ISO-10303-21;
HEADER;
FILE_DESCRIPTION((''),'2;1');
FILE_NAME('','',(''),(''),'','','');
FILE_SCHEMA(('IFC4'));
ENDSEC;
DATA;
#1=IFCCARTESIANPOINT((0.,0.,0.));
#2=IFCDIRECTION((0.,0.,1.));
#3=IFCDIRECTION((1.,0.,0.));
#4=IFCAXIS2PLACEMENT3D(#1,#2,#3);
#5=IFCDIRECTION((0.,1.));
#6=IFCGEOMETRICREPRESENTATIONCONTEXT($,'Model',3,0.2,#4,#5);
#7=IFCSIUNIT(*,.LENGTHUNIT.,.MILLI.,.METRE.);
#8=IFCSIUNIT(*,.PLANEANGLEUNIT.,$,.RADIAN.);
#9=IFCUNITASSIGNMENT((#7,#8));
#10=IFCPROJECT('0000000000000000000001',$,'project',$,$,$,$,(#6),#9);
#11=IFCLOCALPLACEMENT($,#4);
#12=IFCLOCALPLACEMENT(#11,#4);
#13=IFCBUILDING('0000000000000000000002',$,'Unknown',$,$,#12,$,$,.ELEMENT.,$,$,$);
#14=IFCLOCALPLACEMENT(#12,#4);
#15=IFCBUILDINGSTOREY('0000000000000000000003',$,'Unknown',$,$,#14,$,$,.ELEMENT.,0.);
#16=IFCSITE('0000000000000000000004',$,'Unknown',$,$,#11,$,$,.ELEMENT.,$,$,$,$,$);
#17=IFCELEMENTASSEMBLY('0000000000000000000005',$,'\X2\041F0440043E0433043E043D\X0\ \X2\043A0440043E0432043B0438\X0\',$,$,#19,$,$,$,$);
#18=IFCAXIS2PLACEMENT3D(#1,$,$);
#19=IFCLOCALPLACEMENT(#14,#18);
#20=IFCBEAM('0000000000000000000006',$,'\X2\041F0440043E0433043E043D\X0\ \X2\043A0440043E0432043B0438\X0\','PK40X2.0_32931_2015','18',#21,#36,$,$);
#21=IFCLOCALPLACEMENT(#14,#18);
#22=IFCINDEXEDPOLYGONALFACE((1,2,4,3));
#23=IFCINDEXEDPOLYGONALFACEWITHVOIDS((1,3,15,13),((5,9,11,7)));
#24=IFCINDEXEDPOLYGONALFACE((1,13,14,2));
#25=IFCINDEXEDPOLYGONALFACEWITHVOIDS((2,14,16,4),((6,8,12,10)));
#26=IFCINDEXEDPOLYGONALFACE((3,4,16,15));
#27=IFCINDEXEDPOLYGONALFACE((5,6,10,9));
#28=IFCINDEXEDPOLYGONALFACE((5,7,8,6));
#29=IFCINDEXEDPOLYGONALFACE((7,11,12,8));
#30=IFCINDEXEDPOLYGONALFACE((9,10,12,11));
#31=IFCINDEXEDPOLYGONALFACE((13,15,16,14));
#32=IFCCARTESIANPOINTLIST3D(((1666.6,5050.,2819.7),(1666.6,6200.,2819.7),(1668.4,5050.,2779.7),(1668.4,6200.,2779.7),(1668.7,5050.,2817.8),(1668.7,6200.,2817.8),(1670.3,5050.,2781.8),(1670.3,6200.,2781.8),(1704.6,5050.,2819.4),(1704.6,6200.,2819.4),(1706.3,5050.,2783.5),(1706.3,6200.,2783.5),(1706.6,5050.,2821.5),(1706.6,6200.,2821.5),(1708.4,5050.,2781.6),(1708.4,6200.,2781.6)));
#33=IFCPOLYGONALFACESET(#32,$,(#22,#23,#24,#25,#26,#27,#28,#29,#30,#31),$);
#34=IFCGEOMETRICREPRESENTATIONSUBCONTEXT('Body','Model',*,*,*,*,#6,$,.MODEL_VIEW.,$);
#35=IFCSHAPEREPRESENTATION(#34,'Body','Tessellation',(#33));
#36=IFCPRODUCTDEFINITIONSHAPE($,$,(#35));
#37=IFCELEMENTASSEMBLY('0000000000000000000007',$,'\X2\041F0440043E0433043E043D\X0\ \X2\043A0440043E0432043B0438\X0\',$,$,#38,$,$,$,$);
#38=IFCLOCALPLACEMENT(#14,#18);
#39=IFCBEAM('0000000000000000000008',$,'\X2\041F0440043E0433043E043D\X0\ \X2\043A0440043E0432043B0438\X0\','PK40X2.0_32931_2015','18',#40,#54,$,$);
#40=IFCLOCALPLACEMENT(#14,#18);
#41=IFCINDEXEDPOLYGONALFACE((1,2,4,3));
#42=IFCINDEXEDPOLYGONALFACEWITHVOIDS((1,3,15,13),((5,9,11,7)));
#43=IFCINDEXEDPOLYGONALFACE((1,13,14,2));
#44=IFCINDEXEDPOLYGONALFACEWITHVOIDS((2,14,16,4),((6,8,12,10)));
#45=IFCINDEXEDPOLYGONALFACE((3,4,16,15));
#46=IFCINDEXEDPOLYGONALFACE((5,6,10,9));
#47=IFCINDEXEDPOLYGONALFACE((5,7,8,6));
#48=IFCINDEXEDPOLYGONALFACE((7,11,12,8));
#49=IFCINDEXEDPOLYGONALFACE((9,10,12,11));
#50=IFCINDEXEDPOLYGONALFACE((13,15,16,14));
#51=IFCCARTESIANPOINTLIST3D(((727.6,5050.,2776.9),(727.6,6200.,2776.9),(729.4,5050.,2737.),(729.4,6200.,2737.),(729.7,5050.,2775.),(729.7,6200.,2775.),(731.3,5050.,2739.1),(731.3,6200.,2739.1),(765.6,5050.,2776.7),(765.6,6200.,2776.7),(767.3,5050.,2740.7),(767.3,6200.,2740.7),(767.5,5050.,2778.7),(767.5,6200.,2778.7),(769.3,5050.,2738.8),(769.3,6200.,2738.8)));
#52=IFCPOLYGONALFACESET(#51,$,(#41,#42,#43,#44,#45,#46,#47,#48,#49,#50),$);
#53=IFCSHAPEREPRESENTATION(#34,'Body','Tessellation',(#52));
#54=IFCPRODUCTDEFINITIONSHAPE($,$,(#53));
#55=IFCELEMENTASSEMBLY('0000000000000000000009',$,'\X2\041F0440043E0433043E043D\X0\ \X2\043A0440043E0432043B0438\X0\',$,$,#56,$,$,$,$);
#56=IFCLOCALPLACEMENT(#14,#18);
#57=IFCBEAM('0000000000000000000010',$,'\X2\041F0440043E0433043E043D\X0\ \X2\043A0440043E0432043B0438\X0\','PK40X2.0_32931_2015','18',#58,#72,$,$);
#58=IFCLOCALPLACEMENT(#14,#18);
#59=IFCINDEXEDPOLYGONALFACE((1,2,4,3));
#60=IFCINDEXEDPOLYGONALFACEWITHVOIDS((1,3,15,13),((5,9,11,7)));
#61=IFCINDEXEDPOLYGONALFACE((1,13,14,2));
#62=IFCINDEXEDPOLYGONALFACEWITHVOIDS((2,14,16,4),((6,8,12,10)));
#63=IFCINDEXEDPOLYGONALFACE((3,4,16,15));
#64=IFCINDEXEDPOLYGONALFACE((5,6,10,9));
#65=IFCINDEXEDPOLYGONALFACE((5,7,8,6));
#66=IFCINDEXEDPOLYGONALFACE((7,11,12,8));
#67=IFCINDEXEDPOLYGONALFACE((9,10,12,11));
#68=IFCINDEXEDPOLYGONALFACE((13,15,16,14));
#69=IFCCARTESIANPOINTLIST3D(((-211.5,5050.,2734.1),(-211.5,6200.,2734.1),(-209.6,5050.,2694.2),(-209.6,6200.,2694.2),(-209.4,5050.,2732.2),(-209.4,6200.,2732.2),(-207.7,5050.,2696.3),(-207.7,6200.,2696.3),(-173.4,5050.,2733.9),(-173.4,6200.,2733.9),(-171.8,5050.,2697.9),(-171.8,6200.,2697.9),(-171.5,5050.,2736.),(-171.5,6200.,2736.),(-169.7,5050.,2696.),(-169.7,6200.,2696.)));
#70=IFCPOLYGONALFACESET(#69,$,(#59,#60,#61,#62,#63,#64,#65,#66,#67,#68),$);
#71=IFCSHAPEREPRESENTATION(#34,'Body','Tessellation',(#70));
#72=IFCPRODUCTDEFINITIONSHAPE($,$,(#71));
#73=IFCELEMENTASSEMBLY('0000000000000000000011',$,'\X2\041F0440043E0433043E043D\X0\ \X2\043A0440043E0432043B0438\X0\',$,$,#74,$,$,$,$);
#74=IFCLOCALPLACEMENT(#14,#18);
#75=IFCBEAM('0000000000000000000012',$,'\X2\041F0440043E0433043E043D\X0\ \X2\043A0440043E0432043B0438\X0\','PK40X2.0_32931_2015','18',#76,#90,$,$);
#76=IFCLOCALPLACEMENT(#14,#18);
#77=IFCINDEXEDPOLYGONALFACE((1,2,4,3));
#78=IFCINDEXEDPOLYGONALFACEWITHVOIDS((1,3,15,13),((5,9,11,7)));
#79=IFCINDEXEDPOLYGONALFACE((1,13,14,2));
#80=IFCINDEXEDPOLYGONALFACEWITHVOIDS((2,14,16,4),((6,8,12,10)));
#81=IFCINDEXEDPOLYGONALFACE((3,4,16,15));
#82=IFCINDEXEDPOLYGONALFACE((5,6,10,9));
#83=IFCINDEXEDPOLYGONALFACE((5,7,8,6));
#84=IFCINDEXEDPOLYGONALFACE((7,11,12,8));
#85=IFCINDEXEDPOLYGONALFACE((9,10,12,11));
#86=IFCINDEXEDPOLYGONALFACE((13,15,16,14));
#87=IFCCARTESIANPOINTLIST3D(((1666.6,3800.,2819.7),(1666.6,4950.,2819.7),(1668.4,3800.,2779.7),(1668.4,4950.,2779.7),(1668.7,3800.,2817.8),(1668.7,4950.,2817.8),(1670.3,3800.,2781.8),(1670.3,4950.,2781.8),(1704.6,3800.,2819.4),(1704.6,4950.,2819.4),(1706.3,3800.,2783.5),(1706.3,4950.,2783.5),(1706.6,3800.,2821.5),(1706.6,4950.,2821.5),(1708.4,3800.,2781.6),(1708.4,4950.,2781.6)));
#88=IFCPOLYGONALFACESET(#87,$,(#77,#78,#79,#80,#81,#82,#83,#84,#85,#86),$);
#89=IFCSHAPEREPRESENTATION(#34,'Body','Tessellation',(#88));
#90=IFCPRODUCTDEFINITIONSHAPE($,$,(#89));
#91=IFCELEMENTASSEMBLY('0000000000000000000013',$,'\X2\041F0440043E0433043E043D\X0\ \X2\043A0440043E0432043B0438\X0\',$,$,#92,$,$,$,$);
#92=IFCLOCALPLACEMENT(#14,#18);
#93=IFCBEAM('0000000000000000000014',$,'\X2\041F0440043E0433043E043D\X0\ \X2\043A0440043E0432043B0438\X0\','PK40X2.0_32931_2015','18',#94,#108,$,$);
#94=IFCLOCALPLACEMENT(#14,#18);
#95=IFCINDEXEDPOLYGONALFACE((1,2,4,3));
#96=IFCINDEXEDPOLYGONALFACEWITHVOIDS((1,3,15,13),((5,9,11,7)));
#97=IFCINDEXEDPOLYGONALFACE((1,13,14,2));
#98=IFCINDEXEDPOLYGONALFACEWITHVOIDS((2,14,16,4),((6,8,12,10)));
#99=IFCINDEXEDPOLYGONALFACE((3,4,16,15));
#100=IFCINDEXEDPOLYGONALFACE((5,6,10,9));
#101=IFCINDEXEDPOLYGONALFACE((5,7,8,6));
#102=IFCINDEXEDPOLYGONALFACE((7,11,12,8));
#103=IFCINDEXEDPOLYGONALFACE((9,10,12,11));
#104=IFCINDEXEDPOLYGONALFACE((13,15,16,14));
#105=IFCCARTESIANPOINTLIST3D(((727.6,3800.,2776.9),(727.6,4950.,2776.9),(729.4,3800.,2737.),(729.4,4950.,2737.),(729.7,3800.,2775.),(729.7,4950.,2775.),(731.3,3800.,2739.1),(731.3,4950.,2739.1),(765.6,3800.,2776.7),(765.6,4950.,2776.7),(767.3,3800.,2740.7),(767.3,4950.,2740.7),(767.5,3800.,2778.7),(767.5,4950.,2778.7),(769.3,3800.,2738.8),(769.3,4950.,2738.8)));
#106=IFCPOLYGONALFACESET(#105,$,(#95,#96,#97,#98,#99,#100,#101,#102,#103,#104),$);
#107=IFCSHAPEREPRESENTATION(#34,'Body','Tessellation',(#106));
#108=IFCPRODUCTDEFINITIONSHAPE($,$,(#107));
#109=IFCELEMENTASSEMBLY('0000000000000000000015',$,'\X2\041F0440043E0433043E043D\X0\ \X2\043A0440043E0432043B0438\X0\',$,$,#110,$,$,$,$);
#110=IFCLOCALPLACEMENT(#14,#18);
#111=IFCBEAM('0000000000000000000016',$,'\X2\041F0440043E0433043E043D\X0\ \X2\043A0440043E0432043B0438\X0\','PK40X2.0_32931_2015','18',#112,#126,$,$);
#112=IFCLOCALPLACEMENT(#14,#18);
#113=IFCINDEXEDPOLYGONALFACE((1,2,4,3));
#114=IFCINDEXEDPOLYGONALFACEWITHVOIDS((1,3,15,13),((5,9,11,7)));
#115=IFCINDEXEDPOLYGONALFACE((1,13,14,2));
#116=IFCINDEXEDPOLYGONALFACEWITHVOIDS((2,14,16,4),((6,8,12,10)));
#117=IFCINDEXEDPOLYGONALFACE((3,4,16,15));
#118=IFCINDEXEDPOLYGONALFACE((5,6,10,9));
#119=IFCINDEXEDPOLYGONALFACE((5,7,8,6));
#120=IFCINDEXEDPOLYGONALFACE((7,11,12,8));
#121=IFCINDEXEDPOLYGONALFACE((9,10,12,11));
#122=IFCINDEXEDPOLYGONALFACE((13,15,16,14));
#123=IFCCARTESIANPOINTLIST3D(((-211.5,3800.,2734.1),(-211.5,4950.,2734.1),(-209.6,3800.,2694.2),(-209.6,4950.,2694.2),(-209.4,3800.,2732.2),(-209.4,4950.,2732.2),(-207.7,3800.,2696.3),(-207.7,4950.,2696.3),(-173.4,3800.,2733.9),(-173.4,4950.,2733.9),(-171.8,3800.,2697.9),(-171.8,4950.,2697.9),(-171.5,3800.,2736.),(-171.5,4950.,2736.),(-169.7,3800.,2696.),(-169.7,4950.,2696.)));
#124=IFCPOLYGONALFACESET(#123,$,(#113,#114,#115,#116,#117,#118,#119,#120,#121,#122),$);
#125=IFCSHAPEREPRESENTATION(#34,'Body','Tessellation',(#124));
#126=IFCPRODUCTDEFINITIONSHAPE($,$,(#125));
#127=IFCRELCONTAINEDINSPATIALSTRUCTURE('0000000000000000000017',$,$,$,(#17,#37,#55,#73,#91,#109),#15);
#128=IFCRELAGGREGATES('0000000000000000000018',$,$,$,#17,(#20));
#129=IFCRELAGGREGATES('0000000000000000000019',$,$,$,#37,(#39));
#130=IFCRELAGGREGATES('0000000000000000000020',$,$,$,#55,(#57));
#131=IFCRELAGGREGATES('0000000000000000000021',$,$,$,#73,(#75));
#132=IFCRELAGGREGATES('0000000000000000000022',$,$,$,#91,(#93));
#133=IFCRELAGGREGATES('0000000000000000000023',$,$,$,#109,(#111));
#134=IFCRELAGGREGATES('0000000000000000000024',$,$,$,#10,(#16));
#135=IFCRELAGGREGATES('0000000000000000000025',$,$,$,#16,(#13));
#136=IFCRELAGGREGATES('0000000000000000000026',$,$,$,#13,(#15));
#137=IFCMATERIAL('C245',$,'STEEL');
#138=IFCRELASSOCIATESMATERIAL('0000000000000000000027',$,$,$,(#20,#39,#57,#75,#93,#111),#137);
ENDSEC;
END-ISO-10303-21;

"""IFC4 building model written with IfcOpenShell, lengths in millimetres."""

from ifc_helpers import new_model, si_unit, direction, frame, origin_with_axes, place, context, subcontext, project, spatial, line, indexed_curve, outline, extrude, material, element, aggregate, save


model = new_model("IFC4")

# Units and contexts
model_context = context("Model", 3, precision=0.2, world=origin_with_axes(), true_north=direction((0.0, 1.0)))
body_context = subcontext(model_context, "Body", "Model", "MODEL_VIEW")
ifc_project = project(units=[si_unit("LENGTHUNIT", "METRE", prefix="MILLI"), si_unit("PLANEANGLEUNIT", "RADIAN")], contexts=[model_context])

# Site, building, storey
site_placement = place(None, origin_with_axes())
site = spatial("IfcSite", under=ifc_project, at=site_placement, Name="Unknown", CompositionType="ELEMENT")
building_placement = place(site_placement, origin_with_axes())
building = spatial("IfcBuilding", under=site, at=building_placement, Name="Unknown", CompositionType="ELEMENT")
storey_placement = place(building_placement, origin_with_axes())
storey = spatial("IfcBuildingStorey", under=building, at=storey_placement, Name="Unknown", CompositionType="ELEMENT", Elevation=0.0)

# Shared definitions
ifc_material = material(Name="C245", Category="STEEL")

# Element assemblies, beams
assembly_1_placement = place(storey_placement, frame((1687.5, 6200.0, 2800.6), z_axis=(-0.998964, 0.0, -0.045508), x_axis=(0.0, -1.0, 0.0)))
assembly_1 = element("IfcElementAssembly", 1, at=assembly_1_placement, inside=storey, Name="Прогон кровли")
beam_1_placement = place(assembly_1_placement, origin_with_axes())
beam_1 = element("IfcBeam", 2, at=beam_1_placement, material=ifc_material, Name="Прогон кровли", Description="PK40X2.0_32931_2015", ObjectType="18", context=body_context, shape_type="SolidModel", body=[
    extrude(outline(indexed_curve([(-20.0, -20.0), (20.0, -20.0), (20.0, 20.0), (-20.0, 20.0)], segments=[line(1, 2, 3, 4, 1)]), holes=[indexed_curve([(-18.0, -18.0), (-18.0, 18.0), (18.0, 18.0), (18.0, -18.0)], segments=[line(1, 2, 3, 4, 1)])]), frame((0.0, 0.0, 0.0), z_axis=(-1.0, 0.0, 0.0), x_axis=(0.0, 0.0, 1.0)), (0.0, 0.0, -1.0), 1150.0),
])
aggregate(assembly_1, [beam_1])
assembly_2_placement = place(storey_placement, frame((748.5, 6200.0, 2757.9), z_axis=(-0.998964, 0.0, -0.045508), x_axis=(0.0, -1.0, 0.0)))
assembly_2 = element("IfcElementAssembly", 3, at=assembly_2_placement, inside=storey, Name="Прогон кровли")
beam_2_placement = place(assembly_2_placement, origin_with_axes())
beam_2 = element("IfcBeam", 4, at=beam_2_placement, material=ifc_material, Name="Прогон кровли", Description="PK40X2.0_32931_2015", ObjectType="18", context=body_context, shape_type="SolidModel", body=[
    extrude(outline(indexed_curve([(-20.0, -20.0), (20.0, -20.0), (20.0, 20.0), (-20.0, 20.0)], segments=[line(1, 2, 3, 4, 1)]), holes=[indexed_curve([(-18.0, -18.0), (-18.0, 18.0), (18.0, 18.0), (18.0, -18.0)], segments=[line(1, 2, 3, 4, 1)])]), frame((0.0, 0.0, 0.0), z_axis=(-1.0, 0.0, 0.0), x_axis=(0.0, 0.0, 1.0)), (0.0, 0.0, -1.0), 1150.0),
])
aggregate(assembly_2, [beam_2])
assembly_3_placement = place(storey_placement, frame((-190.6, 6200.0, 2715.1), z_axis=(-0.998964, 0.0, -0.045508), x_axis=(0.0, -1.0, 0.0)))
assembly_3 = element("IfcElementAssembly", 5, at=assembly_3_placement, inside=storey, Name="Прогон кровли")
beam_3_placement = place(assembly_3_placement, origin_with_axes())
beam_3 = element("IfcBeam", 6, at=beam_3_placement, material=ifc_material, Name="Прогон кровли", Description="PK40X2.0_32931_2015", ObjectType="18", context=body_context, shape_type="SolidModel", body=[
    extrude(outline(indexed_curve([(-20.0, -20.0), (20.0, -20.0), (20.0, 20.0), (-20.0, 20.0)], segments=[line(1, 2, 3, 4, 1)]), holes=[indexed_curve([(-18.0, -18.0), (-18.0, 18.0), (18.0, 18.0), (18.0, -18.0)], segments=[line(1, 2, 3, 4, 1)])]), frame((0.0, 0.0, 0.0), z_axis=(-1.0, 0.0, 0.0), x_axis=(0.0, 0.0, 1.0)), (0.0, 0.0, -1.0), 1150.0),
])
aggregate(assembly_3, [beam_3])
assembly_4_placement = place(storey_placement, frame((1687.5, 4950.0, 2800.6), z_axis=(-0.998964, 0.0, -0.045508), x_axis=(0.0, -1.0, 0.0)))
assembly_4 = element("IfcElementAssembly", 7, at=assembly_4_placement, inside=storey, Name="Прогон кровли")
beam_4_placement = place(assembly_4_placement, origin_with_axes())
beam_4 = element("IfcBeam", 8, at=beam_4_placement, material=ifc_material, Name="Прогон кровли", Description="PK40X2.0_32931_2015", ObjectType="18", context=body_context, shape_type="SolidModel", body=[
    extrude(outline(indexed_curve([(-20.0, -20.0), (20.0, -20.0), (20.0, 20.0), (-20.0, 20.0)], segments=[line(1, 2, 3, 4, 1)]), holes=[indexed_curve([(-18.0, -18.0), (-18.0, 18.0), (18.0, 18.0), (18.0, -18.0)], segments=[line(1, 2, 3, 4, 1)])]), frame((0.0, 0.0, 0.0), z_axis=(-1.0, 0.0, 0.0), x_axis=(0.0, 0.0, 1.0)), (0.0, 0.0, -1.0), 1150.0),
])
aggregate(assembly_4, [beam_4])
assembly_5_placement = place(storey_placement, frame((748.5, 4950.0, 2757.9), z_axis=(-0.998964, 0.0, -0.045508), x_axis=(0.0, -1.0, 0.0)))
assembly_5 = element("IfcElementAssembly", 9, at=assembly_5_placement, inside=storey, Name="Прогон кровли")
beam_5_placement = place(assembly_5_placement, origin_with_axes())
beam_5 = element("IfcBeam", 10, at=beam_5_placement, material=ifc_material, Name="Прогон кровли", Description="PK40X2.0_32931_2015", ObjectType="18", context=body_context, shape_type="SolidModel", body=[
    extrude(outline(indexed_curve([(-20.0, -20.0), (20.0, -20.0), (20.0, 20.0), (-20.0, 20.0)], segments=[line(1, 2, 3, 4, 1)]), holes=[indexed_curve([(-18.0, -18.0), (-18.0, 18.0), (18.0, 18.0), (18.0, -18.0)], segments=[line(1, 2, 3, 4, 1)])]), frame((0.0, 0.0, 0.0), z_axis=(-1.0, 0.0, 0.0), x_axis=(0.0, 0.0, 1.0)), (0.0, 0.0, -1.0), 1150.0),
])
aggregate(assembly_5, [beam_5])
assembly_6_placement = place(storey_placement, frame((-190.6, 4950.0, 2715.1), z_axis=(-0.998964, 0.0, -0.045508), x_axis=(0.0, -1.0, 0.0)))
assembly_6 = element("IfcElementAssembly", 11, at=assembly_6_placement, inside=storey, Name="Прогон кровли")
beam_6_placement = place(assembly_6_placement, origin_with_axes())
beam_6 = element("IfcBeam", 12, at=beam_6_placement, material=ifc_material, Name="Прогон кровли", Description="PK40X2.0_32931_2015", ObjectType="18", context=body_context, shape_type="SolidModel", body=[
    extrude(outline(indexed_curve([(-20.0, -20.0), (20.0, -20.0), (20.0, 20.0), (-20.0, 20.0)], segments=[line(1, 2, 3, 4, 1)]), holes=[indexed_curve([(-18.0, -18.0), (-18.0, 18.0), (18.0, 18.0), (18.0, -18.0)], segments=[line(1, 2, 3, 4, 1)])]), frame((0.0, 0.0, 0.0), z_axis=(-1.0, 0.0, 0.0), x_axis=(0.0, 0.0, 1.0)), (0.0, 0.0, -1.0), 1150.0),
])
aggregate(assembly_6, [beam_6])

save(model, "model.ifc")
